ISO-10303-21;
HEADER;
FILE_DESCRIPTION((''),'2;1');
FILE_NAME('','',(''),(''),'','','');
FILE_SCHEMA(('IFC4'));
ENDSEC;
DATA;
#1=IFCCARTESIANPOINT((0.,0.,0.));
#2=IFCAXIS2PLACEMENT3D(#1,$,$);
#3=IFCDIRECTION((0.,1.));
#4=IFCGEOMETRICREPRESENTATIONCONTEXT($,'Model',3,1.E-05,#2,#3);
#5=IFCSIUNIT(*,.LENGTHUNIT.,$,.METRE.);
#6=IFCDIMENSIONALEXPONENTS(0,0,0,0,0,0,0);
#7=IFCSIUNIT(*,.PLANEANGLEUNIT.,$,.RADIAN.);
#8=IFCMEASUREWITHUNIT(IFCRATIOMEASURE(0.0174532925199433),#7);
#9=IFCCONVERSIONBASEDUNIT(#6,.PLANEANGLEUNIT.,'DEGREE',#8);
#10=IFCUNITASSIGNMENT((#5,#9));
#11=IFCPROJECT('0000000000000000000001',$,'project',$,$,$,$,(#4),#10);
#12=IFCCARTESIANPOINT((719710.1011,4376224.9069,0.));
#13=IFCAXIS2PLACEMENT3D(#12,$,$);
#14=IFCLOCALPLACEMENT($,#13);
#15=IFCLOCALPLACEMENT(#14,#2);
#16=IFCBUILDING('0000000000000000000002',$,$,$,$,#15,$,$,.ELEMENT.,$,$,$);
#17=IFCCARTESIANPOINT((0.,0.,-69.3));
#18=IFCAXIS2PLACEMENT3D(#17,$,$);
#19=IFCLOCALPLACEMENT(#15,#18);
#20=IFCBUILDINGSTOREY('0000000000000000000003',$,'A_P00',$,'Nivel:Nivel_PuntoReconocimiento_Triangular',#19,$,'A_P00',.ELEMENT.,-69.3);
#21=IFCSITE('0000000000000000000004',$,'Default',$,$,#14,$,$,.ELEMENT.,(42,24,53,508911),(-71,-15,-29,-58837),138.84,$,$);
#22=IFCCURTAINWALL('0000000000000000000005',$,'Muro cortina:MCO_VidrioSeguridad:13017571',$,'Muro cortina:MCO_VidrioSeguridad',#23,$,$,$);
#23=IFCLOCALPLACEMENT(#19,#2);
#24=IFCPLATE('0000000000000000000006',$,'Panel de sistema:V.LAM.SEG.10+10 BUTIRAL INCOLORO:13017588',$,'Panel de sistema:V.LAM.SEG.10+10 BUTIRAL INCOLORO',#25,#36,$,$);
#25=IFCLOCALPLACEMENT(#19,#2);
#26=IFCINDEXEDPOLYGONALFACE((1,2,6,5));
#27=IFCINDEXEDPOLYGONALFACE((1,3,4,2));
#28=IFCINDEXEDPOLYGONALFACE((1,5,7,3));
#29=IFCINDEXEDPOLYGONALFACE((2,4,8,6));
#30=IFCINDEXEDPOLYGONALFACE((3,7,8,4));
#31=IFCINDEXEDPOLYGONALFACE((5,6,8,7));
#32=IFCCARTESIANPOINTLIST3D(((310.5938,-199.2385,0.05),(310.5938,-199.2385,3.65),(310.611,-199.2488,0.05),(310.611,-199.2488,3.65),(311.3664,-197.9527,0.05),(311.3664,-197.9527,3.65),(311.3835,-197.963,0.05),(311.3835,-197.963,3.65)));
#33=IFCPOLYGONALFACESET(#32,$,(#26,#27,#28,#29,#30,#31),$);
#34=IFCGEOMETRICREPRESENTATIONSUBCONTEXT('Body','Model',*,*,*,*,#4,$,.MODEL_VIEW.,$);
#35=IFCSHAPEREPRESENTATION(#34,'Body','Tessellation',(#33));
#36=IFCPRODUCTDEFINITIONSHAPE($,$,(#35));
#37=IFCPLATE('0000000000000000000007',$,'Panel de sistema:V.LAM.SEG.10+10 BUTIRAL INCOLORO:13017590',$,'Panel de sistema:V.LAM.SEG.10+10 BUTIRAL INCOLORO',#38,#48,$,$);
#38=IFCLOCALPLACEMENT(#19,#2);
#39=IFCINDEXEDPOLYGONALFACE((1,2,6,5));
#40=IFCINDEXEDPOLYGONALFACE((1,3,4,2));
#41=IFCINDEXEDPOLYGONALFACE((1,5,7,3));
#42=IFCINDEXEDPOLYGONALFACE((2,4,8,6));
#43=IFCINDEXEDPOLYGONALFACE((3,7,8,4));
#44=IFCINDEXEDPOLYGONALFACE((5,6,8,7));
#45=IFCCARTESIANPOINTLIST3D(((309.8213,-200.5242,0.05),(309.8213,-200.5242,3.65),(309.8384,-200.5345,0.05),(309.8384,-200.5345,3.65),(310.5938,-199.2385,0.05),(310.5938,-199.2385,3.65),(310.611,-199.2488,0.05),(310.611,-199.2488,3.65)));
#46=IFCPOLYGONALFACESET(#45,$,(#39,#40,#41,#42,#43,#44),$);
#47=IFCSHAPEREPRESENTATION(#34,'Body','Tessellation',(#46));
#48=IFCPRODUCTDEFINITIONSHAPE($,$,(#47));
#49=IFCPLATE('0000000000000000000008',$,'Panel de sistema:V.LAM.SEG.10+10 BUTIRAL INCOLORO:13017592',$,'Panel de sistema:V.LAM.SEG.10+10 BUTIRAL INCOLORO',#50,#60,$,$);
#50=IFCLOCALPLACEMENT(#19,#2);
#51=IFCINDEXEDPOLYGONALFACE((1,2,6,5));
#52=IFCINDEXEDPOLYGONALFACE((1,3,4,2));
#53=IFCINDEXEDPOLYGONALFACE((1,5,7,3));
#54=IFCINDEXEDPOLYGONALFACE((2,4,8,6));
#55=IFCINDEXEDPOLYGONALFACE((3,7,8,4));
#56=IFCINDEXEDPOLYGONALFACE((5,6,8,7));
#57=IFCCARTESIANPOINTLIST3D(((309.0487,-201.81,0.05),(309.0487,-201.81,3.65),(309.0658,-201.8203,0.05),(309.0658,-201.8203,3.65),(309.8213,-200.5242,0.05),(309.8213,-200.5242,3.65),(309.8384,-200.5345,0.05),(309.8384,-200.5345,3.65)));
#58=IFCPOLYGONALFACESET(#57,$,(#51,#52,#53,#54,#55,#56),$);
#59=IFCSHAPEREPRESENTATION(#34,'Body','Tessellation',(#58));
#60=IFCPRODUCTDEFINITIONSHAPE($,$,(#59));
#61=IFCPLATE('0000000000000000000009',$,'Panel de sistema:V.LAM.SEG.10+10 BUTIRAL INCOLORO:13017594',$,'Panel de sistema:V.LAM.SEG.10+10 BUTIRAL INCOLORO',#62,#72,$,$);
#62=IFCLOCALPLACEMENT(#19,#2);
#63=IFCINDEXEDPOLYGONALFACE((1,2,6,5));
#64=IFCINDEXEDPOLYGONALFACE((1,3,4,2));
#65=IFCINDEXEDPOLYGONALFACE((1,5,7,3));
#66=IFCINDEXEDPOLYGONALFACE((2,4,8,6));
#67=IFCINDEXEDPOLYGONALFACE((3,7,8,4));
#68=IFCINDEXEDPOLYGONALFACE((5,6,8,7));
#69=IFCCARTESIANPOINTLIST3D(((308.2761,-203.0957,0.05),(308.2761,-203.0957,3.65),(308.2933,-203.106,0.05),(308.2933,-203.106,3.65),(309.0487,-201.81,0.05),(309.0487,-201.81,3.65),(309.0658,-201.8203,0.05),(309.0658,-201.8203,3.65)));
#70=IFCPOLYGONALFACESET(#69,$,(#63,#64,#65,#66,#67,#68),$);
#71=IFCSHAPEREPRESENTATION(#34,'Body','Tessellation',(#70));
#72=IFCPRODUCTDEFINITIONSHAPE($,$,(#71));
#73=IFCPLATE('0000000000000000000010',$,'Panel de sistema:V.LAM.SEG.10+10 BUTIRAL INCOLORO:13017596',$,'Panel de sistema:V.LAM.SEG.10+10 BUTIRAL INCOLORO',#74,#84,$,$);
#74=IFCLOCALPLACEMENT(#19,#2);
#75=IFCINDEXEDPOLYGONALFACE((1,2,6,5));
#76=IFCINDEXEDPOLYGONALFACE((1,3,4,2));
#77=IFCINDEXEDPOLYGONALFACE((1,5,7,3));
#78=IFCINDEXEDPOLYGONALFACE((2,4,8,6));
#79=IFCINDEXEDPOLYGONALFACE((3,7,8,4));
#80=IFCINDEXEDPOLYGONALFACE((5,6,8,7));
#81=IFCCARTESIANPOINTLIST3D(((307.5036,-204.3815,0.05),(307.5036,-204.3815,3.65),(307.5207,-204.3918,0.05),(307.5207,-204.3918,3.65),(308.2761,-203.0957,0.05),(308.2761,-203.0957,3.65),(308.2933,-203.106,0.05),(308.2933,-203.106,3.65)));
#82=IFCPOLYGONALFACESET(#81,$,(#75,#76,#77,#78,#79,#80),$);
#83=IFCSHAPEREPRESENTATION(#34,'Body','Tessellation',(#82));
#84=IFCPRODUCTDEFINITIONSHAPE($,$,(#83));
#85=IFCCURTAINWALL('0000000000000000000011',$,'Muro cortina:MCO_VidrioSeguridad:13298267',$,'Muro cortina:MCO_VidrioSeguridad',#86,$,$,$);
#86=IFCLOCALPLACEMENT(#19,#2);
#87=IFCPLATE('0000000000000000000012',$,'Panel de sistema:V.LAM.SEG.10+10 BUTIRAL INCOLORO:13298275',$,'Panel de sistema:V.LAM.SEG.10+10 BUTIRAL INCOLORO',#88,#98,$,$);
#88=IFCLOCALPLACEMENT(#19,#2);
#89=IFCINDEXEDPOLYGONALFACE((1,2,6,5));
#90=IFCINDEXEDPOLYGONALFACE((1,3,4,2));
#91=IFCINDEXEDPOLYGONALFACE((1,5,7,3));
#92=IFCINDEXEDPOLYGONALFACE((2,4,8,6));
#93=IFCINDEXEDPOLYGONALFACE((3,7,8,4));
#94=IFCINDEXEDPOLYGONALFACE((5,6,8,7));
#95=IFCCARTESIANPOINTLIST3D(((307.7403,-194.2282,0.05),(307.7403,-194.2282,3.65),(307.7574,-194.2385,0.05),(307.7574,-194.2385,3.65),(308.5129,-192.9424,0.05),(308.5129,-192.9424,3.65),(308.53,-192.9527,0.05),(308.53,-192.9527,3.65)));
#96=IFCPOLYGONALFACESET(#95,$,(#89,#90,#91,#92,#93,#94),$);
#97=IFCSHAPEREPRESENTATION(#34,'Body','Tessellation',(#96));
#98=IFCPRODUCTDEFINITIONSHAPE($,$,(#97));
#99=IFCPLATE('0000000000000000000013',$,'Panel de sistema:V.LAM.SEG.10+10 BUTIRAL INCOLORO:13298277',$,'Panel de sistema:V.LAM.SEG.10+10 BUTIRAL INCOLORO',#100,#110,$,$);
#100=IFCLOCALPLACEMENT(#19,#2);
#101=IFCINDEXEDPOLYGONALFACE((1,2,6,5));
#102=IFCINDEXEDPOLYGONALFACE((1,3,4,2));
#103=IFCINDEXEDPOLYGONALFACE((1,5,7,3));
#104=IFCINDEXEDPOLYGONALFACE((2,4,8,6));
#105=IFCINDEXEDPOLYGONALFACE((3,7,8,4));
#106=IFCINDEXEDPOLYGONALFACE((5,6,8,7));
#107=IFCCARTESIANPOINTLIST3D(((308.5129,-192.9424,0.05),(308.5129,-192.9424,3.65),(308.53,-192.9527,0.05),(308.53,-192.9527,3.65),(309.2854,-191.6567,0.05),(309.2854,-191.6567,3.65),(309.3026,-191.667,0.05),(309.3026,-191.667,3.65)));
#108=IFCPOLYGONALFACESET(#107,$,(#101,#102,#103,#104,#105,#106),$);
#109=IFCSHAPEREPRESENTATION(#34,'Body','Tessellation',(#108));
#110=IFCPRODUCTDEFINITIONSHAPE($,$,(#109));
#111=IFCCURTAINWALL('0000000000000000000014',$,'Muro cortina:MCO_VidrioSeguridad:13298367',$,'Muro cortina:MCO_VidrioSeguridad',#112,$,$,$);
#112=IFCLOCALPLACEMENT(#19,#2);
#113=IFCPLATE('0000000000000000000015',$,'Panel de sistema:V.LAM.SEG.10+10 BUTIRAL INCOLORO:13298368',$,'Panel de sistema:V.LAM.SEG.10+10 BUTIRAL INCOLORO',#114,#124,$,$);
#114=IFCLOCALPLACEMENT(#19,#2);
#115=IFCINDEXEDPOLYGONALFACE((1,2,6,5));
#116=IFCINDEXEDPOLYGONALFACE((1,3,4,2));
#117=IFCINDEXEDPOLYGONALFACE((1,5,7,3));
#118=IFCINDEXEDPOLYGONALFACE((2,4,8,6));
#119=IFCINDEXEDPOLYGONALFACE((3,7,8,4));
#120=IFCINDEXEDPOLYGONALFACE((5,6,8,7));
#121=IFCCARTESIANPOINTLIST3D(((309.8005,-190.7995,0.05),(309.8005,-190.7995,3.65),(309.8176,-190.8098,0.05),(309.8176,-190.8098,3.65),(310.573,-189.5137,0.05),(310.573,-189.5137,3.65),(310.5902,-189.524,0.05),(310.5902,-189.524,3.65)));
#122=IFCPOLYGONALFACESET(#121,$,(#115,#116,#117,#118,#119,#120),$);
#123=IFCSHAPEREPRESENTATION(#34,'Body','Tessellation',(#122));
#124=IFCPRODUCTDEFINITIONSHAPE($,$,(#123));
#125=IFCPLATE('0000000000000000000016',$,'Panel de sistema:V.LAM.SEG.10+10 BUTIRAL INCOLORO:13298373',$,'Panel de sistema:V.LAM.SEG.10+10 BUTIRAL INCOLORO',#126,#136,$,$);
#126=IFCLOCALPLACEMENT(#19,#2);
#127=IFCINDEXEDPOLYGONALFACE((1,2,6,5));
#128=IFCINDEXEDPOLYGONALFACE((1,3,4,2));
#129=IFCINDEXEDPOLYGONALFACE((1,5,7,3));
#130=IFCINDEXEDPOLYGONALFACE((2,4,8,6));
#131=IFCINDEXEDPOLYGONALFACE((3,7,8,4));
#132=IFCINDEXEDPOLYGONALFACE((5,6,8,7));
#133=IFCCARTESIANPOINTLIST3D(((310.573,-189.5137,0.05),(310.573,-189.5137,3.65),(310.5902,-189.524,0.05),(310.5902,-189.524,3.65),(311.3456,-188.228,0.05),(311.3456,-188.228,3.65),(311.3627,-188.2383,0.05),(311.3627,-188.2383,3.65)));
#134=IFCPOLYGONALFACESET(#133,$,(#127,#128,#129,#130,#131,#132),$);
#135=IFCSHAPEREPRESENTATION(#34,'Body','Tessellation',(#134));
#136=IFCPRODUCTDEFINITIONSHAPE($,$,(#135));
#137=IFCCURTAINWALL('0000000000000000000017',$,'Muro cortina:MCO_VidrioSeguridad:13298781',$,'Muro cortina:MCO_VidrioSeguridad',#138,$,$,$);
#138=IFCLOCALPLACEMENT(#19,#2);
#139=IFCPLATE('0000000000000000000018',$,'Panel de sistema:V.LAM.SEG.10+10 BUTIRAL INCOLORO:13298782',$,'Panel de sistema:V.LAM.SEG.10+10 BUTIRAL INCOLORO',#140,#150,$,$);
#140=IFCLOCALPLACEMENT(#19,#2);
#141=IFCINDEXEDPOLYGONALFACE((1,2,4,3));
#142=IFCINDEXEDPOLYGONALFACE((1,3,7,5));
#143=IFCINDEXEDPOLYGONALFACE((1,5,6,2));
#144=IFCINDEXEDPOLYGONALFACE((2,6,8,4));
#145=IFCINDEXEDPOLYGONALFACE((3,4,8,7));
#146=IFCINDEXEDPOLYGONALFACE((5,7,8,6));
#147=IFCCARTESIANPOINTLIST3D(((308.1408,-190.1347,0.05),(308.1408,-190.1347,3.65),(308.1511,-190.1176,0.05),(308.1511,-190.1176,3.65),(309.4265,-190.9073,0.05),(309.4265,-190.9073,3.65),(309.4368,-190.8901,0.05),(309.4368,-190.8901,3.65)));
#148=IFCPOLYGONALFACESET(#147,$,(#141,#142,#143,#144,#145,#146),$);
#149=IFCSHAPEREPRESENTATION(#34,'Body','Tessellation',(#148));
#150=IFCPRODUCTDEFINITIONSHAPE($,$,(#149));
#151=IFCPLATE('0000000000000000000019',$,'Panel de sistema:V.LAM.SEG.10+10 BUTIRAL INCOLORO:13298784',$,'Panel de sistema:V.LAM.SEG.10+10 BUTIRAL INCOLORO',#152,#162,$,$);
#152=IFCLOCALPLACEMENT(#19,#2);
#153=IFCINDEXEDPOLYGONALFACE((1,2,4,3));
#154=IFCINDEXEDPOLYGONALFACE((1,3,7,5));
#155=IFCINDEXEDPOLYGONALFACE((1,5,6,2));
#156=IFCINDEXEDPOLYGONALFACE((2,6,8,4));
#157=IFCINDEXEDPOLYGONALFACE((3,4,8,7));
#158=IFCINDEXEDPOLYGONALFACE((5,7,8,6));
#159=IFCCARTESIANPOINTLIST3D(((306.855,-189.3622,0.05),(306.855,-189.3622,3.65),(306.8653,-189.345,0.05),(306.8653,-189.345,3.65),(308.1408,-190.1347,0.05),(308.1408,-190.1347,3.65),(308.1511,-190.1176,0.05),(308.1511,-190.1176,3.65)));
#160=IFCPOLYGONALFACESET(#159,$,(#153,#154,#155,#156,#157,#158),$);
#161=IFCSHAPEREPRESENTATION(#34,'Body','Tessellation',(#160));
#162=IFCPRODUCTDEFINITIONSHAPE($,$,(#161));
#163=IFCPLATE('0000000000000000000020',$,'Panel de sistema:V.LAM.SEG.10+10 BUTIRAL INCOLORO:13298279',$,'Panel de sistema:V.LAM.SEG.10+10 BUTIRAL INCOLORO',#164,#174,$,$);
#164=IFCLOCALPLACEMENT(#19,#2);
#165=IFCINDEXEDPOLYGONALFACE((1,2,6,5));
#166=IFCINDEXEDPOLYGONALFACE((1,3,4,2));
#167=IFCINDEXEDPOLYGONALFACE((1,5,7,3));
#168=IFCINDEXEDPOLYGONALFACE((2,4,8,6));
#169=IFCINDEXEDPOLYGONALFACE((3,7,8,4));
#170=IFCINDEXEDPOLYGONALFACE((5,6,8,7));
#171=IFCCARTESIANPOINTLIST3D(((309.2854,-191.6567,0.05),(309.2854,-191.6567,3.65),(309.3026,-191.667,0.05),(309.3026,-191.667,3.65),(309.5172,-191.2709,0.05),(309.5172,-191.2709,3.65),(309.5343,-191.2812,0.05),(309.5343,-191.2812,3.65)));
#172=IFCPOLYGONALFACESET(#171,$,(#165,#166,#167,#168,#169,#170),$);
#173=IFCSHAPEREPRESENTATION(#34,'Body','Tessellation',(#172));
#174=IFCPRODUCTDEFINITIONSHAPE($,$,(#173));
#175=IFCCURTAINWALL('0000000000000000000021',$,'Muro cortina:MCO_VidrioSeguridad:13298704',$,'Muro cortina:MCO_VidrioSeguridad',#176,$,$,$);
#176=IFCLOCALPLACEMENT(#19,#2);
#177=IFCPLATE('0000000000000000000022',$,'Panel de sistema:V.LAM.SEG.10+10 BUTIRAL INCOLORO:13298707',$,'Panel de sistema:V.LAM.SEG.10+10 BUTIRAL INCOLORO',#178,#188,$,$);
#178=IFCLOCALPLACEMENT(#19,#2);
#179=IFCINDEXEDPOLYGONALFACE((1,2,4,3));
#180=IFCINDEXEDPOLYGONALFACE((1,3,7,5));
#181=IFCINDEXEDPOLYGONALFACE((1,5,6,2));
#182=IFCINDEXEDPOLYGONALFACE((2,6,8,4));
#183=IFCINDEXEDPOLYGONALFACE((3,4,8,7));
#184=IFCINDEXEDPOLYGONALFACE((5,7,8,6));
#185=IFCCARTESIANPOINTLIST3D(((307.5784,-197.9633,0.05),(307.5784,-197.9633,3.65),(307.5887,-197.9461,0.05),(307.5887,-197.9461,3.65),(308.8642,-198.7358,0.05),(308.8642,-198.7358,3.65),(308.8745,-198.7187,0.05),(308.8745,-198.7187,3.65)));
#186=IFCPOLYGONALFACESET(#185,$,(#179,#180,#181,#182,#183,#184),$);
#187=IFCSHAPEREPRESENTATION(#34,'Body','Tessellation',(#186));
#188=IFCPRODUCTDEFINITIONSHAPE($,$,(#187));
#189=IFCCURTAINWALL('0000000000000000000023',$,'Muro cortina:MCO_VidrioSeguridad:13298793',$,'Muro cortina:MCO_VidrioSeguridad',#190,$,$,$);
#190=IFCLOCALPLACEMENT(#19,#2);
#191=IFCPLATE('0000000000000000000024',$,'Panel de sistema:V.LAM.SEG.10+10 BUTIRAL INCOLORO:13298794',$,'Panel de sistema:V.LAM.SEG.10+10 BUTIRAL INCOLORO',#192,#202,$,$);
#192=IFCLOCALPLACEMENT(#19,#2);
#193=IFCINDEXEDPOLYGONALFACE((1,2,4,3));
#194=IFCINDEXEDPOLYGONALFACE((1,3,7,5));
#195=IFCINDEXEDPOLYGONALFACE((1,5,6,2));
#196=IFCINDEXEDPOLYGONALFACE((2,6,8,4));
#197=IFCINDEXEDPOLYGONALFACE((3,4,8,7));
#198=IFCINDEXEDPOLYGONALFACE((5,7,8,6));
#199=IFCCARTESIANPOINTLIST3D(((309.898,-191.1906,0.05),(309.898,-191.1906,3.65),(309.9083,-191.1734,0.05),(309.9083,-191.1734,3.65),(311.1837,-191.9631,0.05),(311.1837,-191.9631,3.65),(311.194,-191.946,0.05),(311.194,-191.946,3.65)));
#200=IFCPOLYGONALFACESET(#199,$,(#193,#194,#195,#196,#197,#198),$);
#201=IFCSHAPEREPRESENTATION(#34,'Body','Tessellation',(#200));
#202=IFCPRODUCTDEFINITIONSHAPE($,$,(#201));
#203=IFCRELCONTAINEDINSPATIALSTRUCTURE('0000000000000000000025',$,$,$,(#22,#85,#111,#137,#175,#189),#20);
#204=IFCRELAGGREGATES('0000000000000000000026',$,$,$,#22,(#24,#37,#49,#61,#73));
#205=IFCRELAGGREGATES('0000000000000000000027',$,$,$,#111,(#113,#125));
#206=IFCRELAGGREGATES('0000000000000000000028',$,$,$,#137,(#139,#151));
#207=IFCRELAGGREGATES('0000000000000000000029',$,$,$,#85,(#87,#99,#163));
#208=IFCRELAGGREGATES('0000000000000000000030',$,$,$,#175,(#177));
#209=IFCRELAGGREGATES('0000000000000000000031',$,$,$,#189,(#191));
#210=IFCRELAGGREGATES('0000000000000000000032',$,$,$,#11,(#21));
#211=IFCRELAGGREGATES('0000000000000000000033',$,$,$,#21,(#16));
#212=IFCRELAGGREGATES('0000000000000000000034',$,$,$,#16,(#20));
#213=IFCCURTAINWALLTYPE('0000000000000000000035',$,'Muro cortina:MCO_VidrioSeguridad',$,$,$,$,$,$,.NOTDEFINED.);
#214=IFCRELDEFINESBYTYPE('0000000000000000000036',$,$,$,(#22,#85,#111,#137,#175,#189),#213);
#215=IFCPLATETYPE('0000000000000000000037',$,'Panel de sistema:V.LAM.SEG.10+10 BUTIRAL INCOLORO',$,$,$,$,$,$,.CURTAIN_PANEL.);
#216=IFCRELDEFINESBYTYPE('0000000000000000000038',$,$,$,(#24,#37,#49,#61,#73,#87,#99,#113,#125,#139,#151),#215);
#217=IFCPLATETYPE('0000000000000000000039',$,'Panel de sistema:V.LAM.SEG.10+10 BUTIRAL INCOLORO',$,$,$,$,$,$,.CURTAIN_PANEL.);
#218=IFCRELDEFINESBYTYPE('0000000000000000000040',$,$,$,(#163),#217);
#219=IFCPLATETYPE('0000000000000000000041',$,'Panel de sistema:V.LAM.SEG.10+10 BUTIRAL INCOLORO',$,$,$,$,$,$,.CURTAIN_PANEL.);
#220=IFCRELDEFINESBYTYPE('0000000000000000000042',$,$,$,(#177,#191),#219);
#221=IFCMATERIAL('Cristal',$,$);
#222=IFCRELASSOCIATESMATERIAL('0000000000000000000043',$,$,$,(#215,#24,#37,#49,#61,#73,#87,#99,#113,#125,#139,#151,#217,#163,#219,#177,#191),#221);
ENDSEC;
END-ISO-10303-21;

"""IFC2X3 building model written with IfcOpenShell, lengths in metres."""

from ifc_helpers import new_model, entity, si_unit, converted_unit, direction, frame, frame_2d, origin, origin_2d_with_axis, place, context, subcontext, project, spatial, rectangle, extrude, source, transform, mapped, material, type_object, type_shapes, element, aggregate, save


model = new_model("IFC2X3")

# Units and contexts
model_context = context("Model", 3, precision=1e-05, world=origin(), true_north=direction((0.0, 1.0)))
body_context = subcontext(model_context, "Body", "Model", "MODEL_VIEW")
ifc_project = project(units=[si_unit("LENGTHUNIT", "METRE"), converted_unit("PLANEANGLEUNIT", "DEGREE", entity("IfcRatioMeasure", 0.0174532925199433), si_unit("PLANEANGLEUNIT", "RADIAN"), dimensions=[0, 0, 0, 0, 0, 0, 0])], contexts=[model_context])

# Site, building, storey
site_placement = place(None, frame((719710.1011, 4376224.9069, 0.0)))
site = spatial("IfcSite", under=ifc_project, at=site_placement, Name="Default", CompositionType="ELEMENT", RefLatitude=(42, 24, 53, 508911), RefLongitude=(-71, -15, -29, -58837), RefElevation=138.84)
building_placement = place(site_placement, origin())
building = spatial("IfcBuilding", under=site, at=building_placement, CompositionType="ELEMENT")
storey_placement = place(building_placement, frame((0.0, 0.0, -69.3)))
storey = spatial("IfcBuildingStorey", under=building, at=storey_placement, Name="A_P00", ObjectType="Nivel:Nivel_PuntoReconocimiento_Triangular", LongName="A_P00", CompositionType="ELEMENT", Elevation=-69.3)

# Curtain walls, plates
curtain_wall_type = type_object("IfcCurtainWallType", Name="Muro cortina:MCO_VidrioSeguridad", PredefinedType="NOTDEFINED")
curtain_wall_1_placement = place(storey_placement, frame((0.0, 0.0, 69.3)))
curtain_wall_1 = element("IfcCurtainWall", 1, at=curtain_wall_1_placement, inside=storey, type_object=curtain_wall_type, Name="Muro cortina:MCO_VidrioSeguridad:13017571", ObjectType="Muro cortina:MCO_VidrioSeguridad")
ifc_material_1 = material(Name="Cristal")
plate_type_1 = type_object("IfcPlateType", Name="Panel de sistema:V.LAM.SEG.10+10 BUTIRAL INCOLORO", PredefinedType="CURTAIN_PANEL", material=ifc_material_1)
shared_shape_1 = source(origin(), body_context, "Body", "SweptSolid", [
    extrude(rectangle(XDim=0.02, YDim=1.5, at=origin_2d_with_axis()), frame((0.0, 0.0, 0.0), z_axis=(0.0, 0.0, 1.0), x_axis=(0.0, 1.0, 0.0)), (0.0, 0.0, 1.0), 3.6),
])
type_shapes(plate_type_1, [shared_shape_1])
plate_1_placement = place(curtain_wall_1_placement, frame((310.9887, -198.6007, -69.25), z_axis=(0.0, 0.0, 1.0), x_axis=(-0.515038, -0.857167, 0.0)))
plate_1 = element("IfcPlate", 2, at=plate_1_placement, type_object=plate_type_1, material=ifc_material_1, Name="Panel de sistema:V.LAM.SEG.10+10 BUTIRAL INCOLORO:13017588", ObjectType="Panel de sistema:V.LAM.SEG.10+10 BUTIRAL INCOLORO", context=body_context, shape_type="MappedRepresentation", body=[
    mapped(shared_shape_1, transform((0.0, 0.0, 0.0), scale=1.0)),
])
plate_2_placement = place(curtain_wall_1_placement, frame((310.2161, -199.8865, -69.25), z_axis=(0.0, 0.0, 1.0), x_axis=(-0.515038, -0.857167, 0.0)))
plate_2 = element("IfcPlate", 3, at=plate_2_placement, type_object=plate_type_1, material=ifc_material_1, Name="Panel de sistema:V.LAM.SEG.10+10 BUTIRAL INCOLORO:13017590", ObjectType="Panel de sistema:V.LAM.SEG.10+10 BUTIRAL INCOLORO", context=body_context, shape_type="MappedRepresentation", body=[
    mapped(shared_shape_1, transform((0.0, 0.0, 0.0), scale=1.0)),
])
plate_3_placement = place(curtain_wall_1_placement, frame((309.4435, -201.1722, -69.25), z_axis=(0.0, 0.0, 1.0), x_axis=(-0.515038, -0.857167, 0.0)))
plate_3 = element("IfcPlate", 4, at=plate_3_placement, type_object=plate_type_1, material=ifc_material_1, Name="Panel de sistema:V.LAM.SEG.10+10 BUTIRAL INCOLORO:13017592", ObjectType="Panel de sistema:V.LAM.SEG.10+10 BUTIRAL INCOLORO", context=body_context, shape_type="MappedRepresentation", body=[
    mapped(shared_shape_1, transform((0.0, 0.0, 0.0), scale=1.0)),
])
plate_4_placement = place(curtain_wall_1_placement, frame((308.671, -202.458, -69.25), z_axis=(0.0, 0.0, 1.0), x_axis=(-0.515038, -0.857167, 0.0)))
plate_4 = element("IfcPlate", 5, at=plate_4_placement, type_object=plate_type_1, material=ifc_material_1, Name="Panel de sistema:V.LAM.SEG.10+10 BUTIRAL INCOLORO:13017594", ObjectType="Panel de sistema:V.LAM.SEG.10+10 BUTIRAL INCOLORO", context=body_context, shape_type="MappedRepresentation", body=[
    mapped(shared_shape_1, transform((0.0, 0.0, 0.0), scale=1.0)),
])
plate_5_placement = place(curtain_wall_1_placement, frame((307.8984, -203.7437, -69.25), z_axis=(0.0, 0.0, 1.0), x_axis=(-0.515038, -0.857167, 0.0)))
plate_5 = element("IfcPlate", 6, at=plate_5_placement, type_object=plate_type_1, material=ifc_material_1, Name="Panel de sistema:V.LAM.SEG.10+10 BUTIRAL INCOLORO:13017596", ObjectType="Panel de sistema:V.LAM.SEG.10+10 BUTIRAL INCOLORO", context=body_context, shape_type="MappedRepresentation", body=[
    mapped(shared_shape_1, transform((0.0, 0.0, 0.0), scale=1.0)),
])
aggregate(curtain_wall_1, [plate_1, plate_2, plate_3, plate_4, plate_5])
curtain_wall_2_placement = place(storey_placement, frame((0.0, 0.0, 69.3)))
curtain_wall_2 = element("IfcCurtainWall", 7, at=curtain_wall_2_placement, inside=storey, type_object=curtain_wall_type, Name="Muro cortina:MCO_VidrioSeguridad:13298267", ObjectType="Muro cortina:MCO_VidrioSeguridad")
plate_6_placement = place(curtain_wall_2_placement, frame((308.1352, -193.5904, -69.25), z_axis=(0.0, 0.0, 1.0), x_axis=(0.515038, 0.857167, 0.0)))
plate_6 = element("IfcPlate", 8, at=plate_6_placement, type_object=plate_type_1, material=ifc_material_1, Name="Panel de sistema:V.LAM.SEG.10+10 BUTIRAL INCOLORO:13298275", ObjectType="Panel de sistema:V.LAM.SEG.10+10 BUTIRAL INCOLORO", context=body_context, shape_type="MappedRepresentation", body=[
    mapped(shared_shape_1, transform((0.0, 0.0, 0.0), scale=1.0)),
])
plate_7_placement = place(curtain_wall_2_placement, frame((308.9077, -192.3047, -69.25), z_axis=(0.0, 0.0, 1.0), x_axis=(0.515038, 0.857167, 0.0)))
plate_7 = element("IfcPlate", 9, at=plate_7_placement, type_object=plate_type_1, material=ifc_material_1, Name="Panel de sistema:V.LAM.SEG.10+10 BUTIRAL INCOLORO:13298277", ObjectType="Panel de sistema:V.LAM.SEG.10+10 BUTIRAL INCOLORO", context=body_context, shape_type="MappedRepresentation", body=[
    mapped(shared_shape_1, transform((0.0, 0.0, 0.0), scale=1.0)),
])
curtain_wall_3_placement = place(storey_placement, frame((0.0, 0.0, 69.3)))
curtain_wall_3 = element("IfcCurtainWall", 10, at=curtain_wall_3_placement, inside=storey, type_object=curtain_wall_type, Name="Muro cortina:MCO_VidrioSeguridad:13298367", ObjectType="Muro cortina:MCO_VidrioSeguridad")
plate_8_placement = place(curtain_wall_3_placement, frame((310.1953, -190.1618, -69.25), z_axis=(0.0, 0.0, 1.0), x_axis=(0.515038, 0.857167, 0.0)))
plate_8 = element("IfcPlate", 11, at=plate_8_placement, type_object=plate_type_1, material=ifc_material_1, Name="Panel de sistema:V.LAM.SEG.10+10 BUTIRAL INCOLORO:13298368", ObjectType="Panel de sistema:V.LAM.SEG.10+10 BUTIRAL INCOLORO", context=body_context, shape_type="MappedRepresentation", body=[
    mapped(shared_shape_1, transform((0.0, 0.0, 0.0), scale=1.0)),
])
plate_9_placement = place(curtain_wall_3_placement, frame((310.9679, -188.876, -69.25), z_axis=(0.0, 0.0, 1.0), x_axis=(0.515038, 0.857167, 0.0)))
plate_9 = element("IfcPlate", 12, at=plate_9_placement, type_object=plate_type_1, material=ifc_material_1, Name="Panel de sistema:V.LAM.SEG.10+10 BUTIRAL INCOLORO:13298373", ObjectType="Panel de sistema:V.LAM.SEG.10+10 BUTIRAL INCOLORO", context=body_context, shape_type="MappedRepresentation", body=[
    mapped(shared_shape_1, transform((0.0, 0.0, 0.0), scale=1.0)),
])
aggregate(curtain_wall_3, [plate_8, plate_9])
curtain_wall_4_placement = place(storey_placement, frame((0.0, 0.0, 69.3)))
curtain_wall_4 = element("IfcCurtainWall", 13, at=curtain_wall_4_placement, inside=storey, type_object=curtain_wall_type, Name="Muro cortina:MCO_VidrioSeguridad:13298781", ObjectType="Muro cortina:MCO_VidrioSeguridad")
plate_10_placement = place(curtain_wall_4_placement, frame((308.7888, -190.5124, -69.25), z_axis=(0.0, 0.0, 1.0), x_axis=(-0.857167, 0.515038, 0.0)))
plate_10 = element("IfcPlate", 14, at=plate_10_placement, type_object=plate_type_1, material=ifc_material_1, Name="Panel de sistema:V.LAM.SEG.10+10 BUTIRAL INCOLORO:13298782", ObjectType="Panel de sistema:V.LAM.SEG.10+10 BUTIRAL INCOLORO", context=body_context, shape_type="MappedRepresentation", body=[
    mapped(shared_shape_1, transform((0.0, 0.0, 0.0), scale=1.0)),
])
plate_11_placement = place(curtain_wall_4_placement, frame((307.503, -189.7399, -69.25), z_axis=(0.0, 0.0, 1.0), x_axis=(-0.857167, 0.515038, 0.0)))
plate_11 = element("IfcPlate", 15, at=plate_11_placement, type_object=plate_type_1, material=ifc_material_1, Name="Panel de sistema:V.LAM.SEG.10+10 BUTIRAL INCOLORO:13298784", ObjectType="Panel de sistema:V.LAM.SEG.10+10 BUTIRAL INCOLORO", context=body_context, shape_type="MappedRepresentation", body=[
    mapped(shared_shape_1, transform((0.0, 0.0, 0.0), scale=1.0)),
])
aggregate(curtain_wall_4, [plate_10, plate_11])

# Plate
plate_type_2 = type_object("IfcPlateType", Name="Panel de sistema:V.LAM.SEG.10+10 BUTIRAL INCOLORO", PredefinedType="CURTAIN_PANEL", material=ifc_material_1)
shared_shape_2 = source(origin(), body_context, "Body", "SweptSolid", [
    extrude(rectangle(XDim=0.02, YDim=0.45, at=origin_2d_with_axis()), frame((0.0, 0.0, 0.0), z_axis=(0.0, 0.0, 1.0), x_axis=(0.0, 1.0, 0.0)), (0.0, 0.0, 1.0), 3.6),
])
type_shapes(plate_type_2, [shared_shape_2])
plate_12_placement = place(curtain_wall_2_placement, frame((309.4099, -191.4689, -69.25), z_axis=(0.0, 0.0, 1.0), x_axis=(0.515038, 0.857167, 0.0)))
plate_12 = element("IfcPlate", 16, at=plate_12_placement, type_object=plate_type_2, material=ifc_material_1, Name="Panel de sistema:V.LAM.SEG.10+10 BUTIRAL INCOLORO:13298279", ObjectType="Panel de sistema:V.LAM.SEG.10+10 BUTIRAL INCOLORO", context=body_context, shape_type="MappedRepresentation", body=[
    mapped(shared_shape_2, transform((0.0, 0.0, 0.0), scale=1.0)),
])
aggregate(curtain_wall_2, [plate_6, plate_7, plate_12])

# Curtain walls, plates
curtain_wall_5_placement = place(storey_placement, frame((0.0, 0.0, 69.3)))
curtain_wall_5 = element("IfcCurtainWall", 17, at=curtain_wall_5_placement, inside=storey, type_object=curtain_wall_type, Name="Muro cortina:MCO_VidrioSeguridad:13298704", ObjectType="Muro cortina:MCO_VidrioSeguridad")
plate_type_3 = type_object("IfcPlateType", Name="Panel de sistema:V.LAM.SEG.10+10 BUTIRAL INCOLORO", PredefinedType="CURTAIN_PANEL", material=ifc_material_1)
shared_shape_3 = source(origin(), body_context, "Body", "SweptSolid", [
    extrude(rectangle(XDim=0.02, YDim=1.5, at=frame_2d((0.0, 0.0), x_axis=(1.0, 0.0))), frame((0.0, 0.0, 0.0), z_axis=(0.0, 0.0, 1.0), x_axis=(0.0, 1.0, 0.0)), (0.0, 0.0, 1.0), 3.6),
])
type_shapes(plate_type_3, [shared_shape_3])
plate_13_placement = place(curtain_wall_5_placement, frame((308.2265, -198.341, -69.25), z_axis=(0.0, 0.0, 1.0), x_axis=(0.857167, -0.515038, 0.0)))
plate_13 = element("IfcPlate", 18, at=plate_13_placement, type_object=plate_type_3, material=ifc_material_1, Name="Panel de sistema:V.LAM.SEG.10+10 BUTIRAL INCOLORO:13298707", ObjectType="Panel de sistema:V.LAM.SEG.10+10 BUTIRAL INCOLORO", context=body_context, shape_type="MappedRepresentation", body=[
    mapped(shared_shape_3, transform((0.0, 0.0, 0.0), scale=1.0)),
])
aggregate(curtain_wall_5, [plate_13])
curtain_wall_6_placement = place(storey_placement, frame((0.0, 0.0, 69.3)))
curtain_wall_6 = element("IfcCurtainWall", 19, at=curtain_wall_6_placement, inside=storey, type_object=curtain_wall_type, Name="Muro cortina:MCO_VidrioSeguridad:13298793", ObjectType="Muro cortina:MCO_VidrioSeguridad")
plate_14_placement = place(curtain_wall_6_placement, frame((310.546, -191.5683, -69.25), z_axis=(0.0, 0.0, 1.0), x_axis=(0.857167, -0.515038, 0.0)))
plate_14 = element("IfcPlate", 20, at=plate_14_placement, type_object=plate_type_3, material=ifc_material_1, Name="Panel de sistema:V.LAM.SEG.10+10 BUTIRAL INCOLORO:13298794", ObjectType="Panel de sistema:V.LAM.SEG.10+10 BUTIRAL INCOLORO", context=body_context, shape_type="MappedRepresentation", body=[
    mapped(shared_shape_3, transform((0.0, 0.0, 0.0), scale=1.0)),
])
aggregate(curtain_wall_6, [plate_14])

save(model, "model.ifc")
